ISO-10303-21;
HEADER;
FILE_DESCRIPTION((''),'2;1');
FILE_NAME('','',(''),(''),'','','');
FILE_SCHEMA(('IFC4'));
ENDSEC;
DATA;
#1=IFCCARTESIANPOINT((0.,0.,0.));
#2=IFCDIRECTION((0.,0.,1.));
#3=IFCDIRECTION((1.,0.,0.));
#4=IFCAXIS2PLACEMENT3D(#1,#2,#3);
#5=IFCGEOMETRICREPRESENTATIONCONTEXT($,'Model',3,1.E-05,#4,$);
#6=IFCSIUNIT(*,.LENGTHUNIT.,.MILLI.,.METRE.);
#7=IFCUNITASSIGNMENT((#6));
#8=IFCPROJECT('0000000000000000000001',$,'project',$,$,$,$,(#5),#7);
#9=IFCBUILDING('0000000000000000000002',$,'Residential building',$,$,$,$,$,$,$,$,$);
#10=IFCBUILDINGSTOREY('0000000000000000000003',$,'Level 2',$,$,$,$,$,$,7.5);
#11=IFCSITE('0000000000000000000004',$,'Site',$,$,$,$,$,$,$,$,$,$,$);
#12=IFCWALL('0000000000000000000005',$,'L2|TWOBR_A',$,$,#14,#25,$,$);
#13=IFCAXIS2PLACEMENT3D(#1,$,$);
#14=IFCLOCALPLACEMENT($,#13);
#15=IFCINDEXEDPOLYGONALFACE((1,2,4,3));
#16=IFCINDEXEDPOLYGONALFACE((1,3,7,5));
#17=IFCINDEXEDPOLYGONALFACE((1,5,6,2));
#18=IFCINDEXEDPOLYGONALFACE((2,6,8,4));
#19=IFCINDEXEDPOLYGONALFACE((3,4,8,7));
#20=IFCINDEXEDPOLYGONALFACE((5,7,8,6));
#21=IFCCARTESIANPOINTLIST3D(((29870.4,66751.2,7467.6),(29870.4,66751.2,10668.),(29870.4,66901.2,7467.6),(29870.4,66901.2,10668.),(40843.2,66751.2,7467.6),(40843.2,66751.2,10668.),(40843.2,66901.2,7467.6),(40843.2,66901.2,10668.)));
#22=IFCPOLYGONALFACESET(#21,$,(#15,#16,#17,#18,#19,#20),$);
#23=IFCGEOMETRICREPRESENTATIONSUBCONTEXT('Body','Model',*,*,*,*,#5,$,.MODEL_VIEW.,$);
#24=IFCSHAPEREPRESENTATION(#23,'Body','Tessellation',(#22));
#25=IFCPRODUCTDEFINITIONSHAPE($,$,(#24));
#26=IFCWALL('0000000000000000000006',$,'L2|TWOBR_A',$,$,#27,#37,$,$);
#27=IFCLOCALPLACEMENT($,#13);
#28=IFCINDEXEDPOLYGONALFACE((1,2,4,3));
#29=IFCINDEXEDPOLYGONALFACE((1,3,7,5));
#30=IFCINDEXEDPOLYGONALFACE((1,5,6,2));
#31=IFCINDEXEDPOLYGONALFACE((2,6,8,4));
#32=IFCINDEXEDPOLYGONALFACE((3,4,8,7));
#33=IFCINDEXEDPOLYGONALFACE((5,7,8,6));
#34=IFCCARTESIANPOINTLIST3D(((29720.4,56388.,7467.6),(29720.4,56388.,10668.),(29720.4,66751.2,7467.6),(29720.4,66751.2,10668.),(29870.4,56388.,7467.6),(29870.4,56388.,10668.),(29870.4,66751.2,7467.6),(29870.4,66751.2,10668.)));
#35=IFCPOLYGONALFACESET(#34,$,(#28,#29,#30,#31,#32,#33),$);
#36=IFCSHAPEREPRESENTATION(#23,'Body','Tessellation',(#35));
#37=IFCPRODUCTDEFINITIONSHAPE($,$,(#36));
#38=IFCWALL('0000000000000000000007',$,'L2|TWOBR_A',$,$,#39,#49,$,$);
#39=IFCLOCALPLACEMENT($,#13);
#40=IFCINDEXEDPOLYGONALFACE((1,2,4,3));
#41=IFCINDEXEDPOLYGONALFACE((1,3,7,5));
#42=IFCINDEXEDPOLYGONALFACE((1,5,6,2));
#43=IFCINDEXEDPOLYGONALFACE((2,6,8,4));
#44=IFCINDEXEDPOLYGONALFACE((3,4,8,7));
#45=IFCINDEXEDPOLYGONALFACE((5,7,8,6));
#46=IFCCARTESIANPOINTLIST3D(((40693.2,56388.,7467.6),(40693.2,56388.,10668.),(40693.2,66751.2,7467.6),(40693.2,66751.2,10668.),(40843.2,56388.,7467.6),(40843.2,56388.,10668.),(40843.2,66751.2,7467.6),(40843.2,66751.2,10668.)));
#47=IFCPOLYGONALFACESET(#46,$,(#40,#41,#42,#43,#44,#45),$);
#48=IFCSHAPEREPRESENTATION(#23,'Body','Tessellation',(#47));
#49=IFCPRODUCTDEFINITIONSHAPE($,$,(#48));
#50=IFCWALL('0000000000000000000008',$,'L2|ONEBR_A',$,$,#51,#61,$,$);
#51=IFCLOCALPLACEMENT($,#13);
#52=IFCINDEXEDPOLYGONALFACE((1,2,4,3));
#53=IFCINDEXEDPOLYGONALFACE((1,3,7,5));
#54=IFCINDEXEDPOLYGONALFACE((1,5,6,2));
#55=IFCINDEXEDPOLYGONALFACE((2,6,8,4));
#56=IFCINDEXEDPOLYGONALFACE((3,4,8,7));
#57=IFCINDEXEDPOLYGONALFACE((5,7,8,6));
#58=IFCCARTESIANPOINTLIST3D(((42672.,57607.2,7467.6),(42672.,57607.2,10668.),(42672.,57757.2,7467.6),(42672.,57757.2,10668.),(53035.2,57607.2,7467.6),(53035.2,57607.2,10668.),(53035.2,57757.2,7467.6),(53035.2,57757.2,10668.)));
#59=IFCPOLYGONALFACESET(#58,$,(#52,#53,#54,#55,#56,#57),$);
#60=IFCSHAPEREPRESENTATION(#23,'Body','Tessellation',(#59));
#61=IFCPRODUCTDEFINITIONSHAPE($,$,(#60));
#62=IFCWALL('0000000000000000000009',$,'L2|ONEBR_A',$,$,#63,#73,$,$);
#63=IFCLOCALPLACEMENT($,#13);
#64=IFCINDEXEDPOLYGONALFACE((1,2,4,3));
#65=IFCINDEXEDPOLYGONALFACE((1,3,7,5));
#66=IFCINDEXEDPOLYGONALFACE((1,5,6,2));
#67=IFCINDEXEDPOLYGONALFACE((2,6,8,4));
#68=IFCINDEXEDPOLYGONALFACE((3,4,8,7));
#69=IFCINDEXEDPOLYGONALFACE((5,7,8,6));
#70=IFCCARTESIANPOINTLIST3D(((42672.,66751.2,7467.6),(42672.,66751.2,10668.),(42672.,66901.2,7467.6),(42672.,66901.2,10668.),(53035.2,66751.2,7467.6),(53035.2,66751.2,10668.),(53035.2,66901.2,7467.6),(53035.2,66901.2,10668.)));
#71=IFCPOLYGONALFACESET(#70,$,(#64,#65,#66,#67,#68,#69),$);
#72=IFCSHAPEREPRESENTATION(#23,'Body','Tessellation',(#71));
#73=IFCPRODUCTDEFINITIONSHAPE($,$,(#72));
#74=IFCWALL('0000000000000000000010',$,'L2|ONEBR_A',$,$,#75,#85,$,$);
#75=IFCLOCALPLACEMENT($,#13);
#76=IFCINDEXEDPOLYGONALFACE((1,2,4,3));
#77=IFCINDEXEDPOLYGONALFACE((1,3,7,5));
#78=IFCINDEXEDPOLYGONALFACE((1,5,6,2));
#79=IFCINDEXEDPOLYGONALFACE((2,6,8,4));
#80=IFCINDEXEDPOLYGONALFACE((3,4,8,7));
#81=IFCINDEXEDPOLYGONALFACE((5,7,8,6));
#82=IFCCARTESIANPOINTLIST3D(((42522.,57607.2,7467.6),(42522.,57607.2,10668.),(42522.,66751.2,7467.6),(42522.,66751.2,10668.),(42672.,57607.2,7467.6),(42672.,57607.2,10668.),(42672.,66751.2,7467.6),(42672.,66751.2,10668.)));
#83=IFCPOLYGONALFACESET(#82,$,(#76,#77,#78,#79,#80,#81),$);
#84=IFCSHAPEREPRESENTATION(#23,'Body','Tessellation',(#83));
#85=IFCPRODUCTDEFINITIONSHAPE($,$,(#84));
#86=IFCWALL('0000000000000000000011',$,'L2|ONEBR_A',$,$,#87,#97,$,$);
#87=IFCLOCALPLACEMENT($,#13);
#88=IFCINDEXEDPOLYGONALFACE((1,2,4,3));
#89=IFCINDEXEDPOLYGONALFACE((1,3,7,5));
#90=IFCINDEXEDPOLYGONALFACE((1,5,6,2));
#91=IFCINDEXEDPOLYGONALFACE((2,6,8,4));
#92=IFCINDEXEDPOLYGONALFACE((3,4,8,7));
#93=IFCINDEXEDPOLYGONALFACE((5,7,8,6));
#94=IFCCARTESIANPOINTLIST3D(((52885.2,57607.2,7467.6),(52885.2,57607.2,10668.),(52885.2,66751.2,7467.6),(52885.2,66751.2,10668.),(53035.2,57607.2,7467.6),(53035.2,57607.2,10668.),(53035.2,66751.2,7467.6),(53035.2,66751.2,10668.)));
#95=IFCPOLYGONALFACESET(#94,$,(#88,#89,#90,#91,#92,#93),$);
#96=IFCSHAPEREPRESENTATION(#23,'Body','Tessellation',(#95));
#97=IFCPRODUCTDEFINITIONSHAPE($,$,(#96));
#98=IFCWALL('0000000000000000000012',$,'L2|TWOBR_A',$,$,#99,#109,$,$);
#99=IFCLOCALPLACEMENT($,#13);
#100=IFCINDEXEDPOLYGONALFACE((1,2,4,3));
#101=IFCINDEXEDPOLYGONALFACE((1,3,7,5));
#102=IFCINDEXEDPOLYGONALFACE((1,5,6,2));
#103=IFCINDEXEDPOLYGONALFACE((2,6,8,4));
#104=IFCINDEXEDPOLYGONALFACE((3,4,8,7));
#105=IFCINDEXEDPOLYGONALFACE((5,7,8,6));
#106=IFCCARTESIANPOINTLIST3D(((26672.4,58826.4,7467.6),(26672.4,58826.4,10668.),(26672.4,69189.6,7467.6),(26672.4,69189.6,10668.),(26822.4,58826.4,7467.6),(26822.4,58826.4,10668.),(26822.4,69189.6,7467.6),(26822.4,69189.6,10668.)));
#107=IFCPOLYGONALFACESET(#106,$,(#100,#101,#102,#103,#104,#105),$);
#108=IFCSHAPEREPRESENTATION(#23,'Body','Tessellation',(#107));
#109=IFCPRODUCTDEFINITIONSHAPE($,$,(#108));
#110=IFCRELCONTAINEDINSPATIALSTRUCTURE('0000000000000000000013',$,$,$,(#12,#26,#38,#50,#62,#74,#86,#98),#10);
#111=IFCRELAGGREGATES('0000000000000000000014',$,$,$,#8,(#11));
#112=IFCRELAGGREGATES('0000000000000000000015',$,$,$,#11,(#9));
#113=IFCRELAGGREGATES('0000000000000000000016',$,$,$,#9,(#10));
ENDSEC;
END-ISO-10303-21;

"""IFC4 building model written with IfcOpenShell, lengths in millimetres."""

from ifc_helpers import new_model, si_unit, frame, origin_with_axes, place, context, subcontext, project, spatial, indexed_curve, outline, extrude, element, save


model = new_model("IFC4")

# Units and contexts
model_context = context("Model", 3, precision=1e-05, world=origin_with_axes())
body_context = subcontext(model_context, "Body", "Model", "MODEL_VIEW")
ifc_project = project(units=[si_unit("LENGTHUNIT", "METRE", prefix="MILLI")], contexts=[model_context])

# Site, building, storey
site = spatial("IfcSite", under=ifc_project, Name="Site")
building = spatial("IfcBuilding", under=site, Name="Residential building")
storey = spatial("IfcBuildingStorey", under=building, Name="Level 2", Elevation=7.5)

# Walls
for number, where, z_axis, x_axis, name in (
    (1, (29870.4, 66751.2, 7467.6), (0.0, 0.0, 1.0), (1.0, 0.0, 0.0), "L2|TWOBR_A"),
):
    element("IfcWall", number, at=place(None, frame(where, z_axis=z_axis, x_axis=x_axis)), inside=storey, Name=name, context=body_context, shape_type="SweptSolid", body=[
        extrude(outline(indexed_curve([(0.0, 0.0), (0.0, 150.0), (10972.8, 150.0), (10972.8, 0.0), (0.0, 0.0)], self_intersect=False)), origin_with_axes(), (0.0, 0.0, 1.0), 3200.4),
    ])
for number, where, z_axis, x_axis, name in (
    (2, (29870.4, 56388.0, 7467.6), (0.0, 0.0, 1.0), (0.0, 1.0, 0.0), "L2|TWOBR_A"),
    (3, (40843.2, 56388.0, 7467.6), (0.0, 0.0, 1.0), (0.0, 1.0, 0.0), "L2|TWOBR_A"),
    (4, (42672.0, 57607.2, 7467.6), (0.0, 0.0, 1.0), (1.0, 0.0, 0.0), "L2|ONEBR_A"),
    (5, (42672.0, 66751.2, 7467.6), (0.0, 0.0, 1.0), (1.0, 0.0, 0.0), "L2|ONEBR_A"),
):
    element("IfcWall", number, at=place(None, frame(where, z_axis=z_axis, x_axis=x_axis)), inside=storey, Name=name, context=body_context, shape_type="SweptSolid", body=[
        extrude(outline(indexed_curve([(0.0, 0.0), (0.0, 150.0), (10363.2, 150.0), (10363.2, 0.0), (0.0, 0.0)], self_intersect=False)), origin_with_axes(), (0.0, 0.0, 1.0), 3200.4),
    ])
for number, where, z_axis, x_axis, name in (
    (6, (42672.0, 57607.2, 7467.6), (0.0, 0.0, 1.0), (0.0, 1.0, 0.0), "L2|ONEBR_A"),
    (7, (53035.2, 57607.2, 7467.6), (0.0, 0.0, 1.0), (0.0, 1.0, 0.0), "L2|ONEBR_A"),
):
    element("IfcWall", number, at=place(None, frame(where, z_axis=z_axis, x_axis=x_axis)), inside=storey, Name=name, context=body_context, shape_type="SweptSolid", body=[
        extrude(outline(indexed_curve([(0.0, 0.0), (0.0, 150.0), (9144.0, 150.0), (9144.0, 0.0), (0.0, 0.0)], self_intersect=False)), origin_with_axes(), (0.0, 0.0, 1.0), 3200.4),
    ])
wall_placement = place(None, frame((26822.4, 58826.4, 7467.6), z_axis=(0.0, 0.0, 1.0), x_axis=(0.0, 1.0, 0.0)))
element("IfcWall", 8, at=wall_placement, inside=storey, Name="L2|TWOBR_A", context=body_context, shape_type="SweptSolid", body=[
    extrude(outline(indexed_curve([(0.0, 0.0), (0.0, 150.0), (10363.2, 150.0), (10363.2, 0.0), (0.0, 0.0)], self_intersect=False)), origin_with_axes(), (0.0, 0.0, 1.0), 3200.4),
])

save(model, "model.ifc")
